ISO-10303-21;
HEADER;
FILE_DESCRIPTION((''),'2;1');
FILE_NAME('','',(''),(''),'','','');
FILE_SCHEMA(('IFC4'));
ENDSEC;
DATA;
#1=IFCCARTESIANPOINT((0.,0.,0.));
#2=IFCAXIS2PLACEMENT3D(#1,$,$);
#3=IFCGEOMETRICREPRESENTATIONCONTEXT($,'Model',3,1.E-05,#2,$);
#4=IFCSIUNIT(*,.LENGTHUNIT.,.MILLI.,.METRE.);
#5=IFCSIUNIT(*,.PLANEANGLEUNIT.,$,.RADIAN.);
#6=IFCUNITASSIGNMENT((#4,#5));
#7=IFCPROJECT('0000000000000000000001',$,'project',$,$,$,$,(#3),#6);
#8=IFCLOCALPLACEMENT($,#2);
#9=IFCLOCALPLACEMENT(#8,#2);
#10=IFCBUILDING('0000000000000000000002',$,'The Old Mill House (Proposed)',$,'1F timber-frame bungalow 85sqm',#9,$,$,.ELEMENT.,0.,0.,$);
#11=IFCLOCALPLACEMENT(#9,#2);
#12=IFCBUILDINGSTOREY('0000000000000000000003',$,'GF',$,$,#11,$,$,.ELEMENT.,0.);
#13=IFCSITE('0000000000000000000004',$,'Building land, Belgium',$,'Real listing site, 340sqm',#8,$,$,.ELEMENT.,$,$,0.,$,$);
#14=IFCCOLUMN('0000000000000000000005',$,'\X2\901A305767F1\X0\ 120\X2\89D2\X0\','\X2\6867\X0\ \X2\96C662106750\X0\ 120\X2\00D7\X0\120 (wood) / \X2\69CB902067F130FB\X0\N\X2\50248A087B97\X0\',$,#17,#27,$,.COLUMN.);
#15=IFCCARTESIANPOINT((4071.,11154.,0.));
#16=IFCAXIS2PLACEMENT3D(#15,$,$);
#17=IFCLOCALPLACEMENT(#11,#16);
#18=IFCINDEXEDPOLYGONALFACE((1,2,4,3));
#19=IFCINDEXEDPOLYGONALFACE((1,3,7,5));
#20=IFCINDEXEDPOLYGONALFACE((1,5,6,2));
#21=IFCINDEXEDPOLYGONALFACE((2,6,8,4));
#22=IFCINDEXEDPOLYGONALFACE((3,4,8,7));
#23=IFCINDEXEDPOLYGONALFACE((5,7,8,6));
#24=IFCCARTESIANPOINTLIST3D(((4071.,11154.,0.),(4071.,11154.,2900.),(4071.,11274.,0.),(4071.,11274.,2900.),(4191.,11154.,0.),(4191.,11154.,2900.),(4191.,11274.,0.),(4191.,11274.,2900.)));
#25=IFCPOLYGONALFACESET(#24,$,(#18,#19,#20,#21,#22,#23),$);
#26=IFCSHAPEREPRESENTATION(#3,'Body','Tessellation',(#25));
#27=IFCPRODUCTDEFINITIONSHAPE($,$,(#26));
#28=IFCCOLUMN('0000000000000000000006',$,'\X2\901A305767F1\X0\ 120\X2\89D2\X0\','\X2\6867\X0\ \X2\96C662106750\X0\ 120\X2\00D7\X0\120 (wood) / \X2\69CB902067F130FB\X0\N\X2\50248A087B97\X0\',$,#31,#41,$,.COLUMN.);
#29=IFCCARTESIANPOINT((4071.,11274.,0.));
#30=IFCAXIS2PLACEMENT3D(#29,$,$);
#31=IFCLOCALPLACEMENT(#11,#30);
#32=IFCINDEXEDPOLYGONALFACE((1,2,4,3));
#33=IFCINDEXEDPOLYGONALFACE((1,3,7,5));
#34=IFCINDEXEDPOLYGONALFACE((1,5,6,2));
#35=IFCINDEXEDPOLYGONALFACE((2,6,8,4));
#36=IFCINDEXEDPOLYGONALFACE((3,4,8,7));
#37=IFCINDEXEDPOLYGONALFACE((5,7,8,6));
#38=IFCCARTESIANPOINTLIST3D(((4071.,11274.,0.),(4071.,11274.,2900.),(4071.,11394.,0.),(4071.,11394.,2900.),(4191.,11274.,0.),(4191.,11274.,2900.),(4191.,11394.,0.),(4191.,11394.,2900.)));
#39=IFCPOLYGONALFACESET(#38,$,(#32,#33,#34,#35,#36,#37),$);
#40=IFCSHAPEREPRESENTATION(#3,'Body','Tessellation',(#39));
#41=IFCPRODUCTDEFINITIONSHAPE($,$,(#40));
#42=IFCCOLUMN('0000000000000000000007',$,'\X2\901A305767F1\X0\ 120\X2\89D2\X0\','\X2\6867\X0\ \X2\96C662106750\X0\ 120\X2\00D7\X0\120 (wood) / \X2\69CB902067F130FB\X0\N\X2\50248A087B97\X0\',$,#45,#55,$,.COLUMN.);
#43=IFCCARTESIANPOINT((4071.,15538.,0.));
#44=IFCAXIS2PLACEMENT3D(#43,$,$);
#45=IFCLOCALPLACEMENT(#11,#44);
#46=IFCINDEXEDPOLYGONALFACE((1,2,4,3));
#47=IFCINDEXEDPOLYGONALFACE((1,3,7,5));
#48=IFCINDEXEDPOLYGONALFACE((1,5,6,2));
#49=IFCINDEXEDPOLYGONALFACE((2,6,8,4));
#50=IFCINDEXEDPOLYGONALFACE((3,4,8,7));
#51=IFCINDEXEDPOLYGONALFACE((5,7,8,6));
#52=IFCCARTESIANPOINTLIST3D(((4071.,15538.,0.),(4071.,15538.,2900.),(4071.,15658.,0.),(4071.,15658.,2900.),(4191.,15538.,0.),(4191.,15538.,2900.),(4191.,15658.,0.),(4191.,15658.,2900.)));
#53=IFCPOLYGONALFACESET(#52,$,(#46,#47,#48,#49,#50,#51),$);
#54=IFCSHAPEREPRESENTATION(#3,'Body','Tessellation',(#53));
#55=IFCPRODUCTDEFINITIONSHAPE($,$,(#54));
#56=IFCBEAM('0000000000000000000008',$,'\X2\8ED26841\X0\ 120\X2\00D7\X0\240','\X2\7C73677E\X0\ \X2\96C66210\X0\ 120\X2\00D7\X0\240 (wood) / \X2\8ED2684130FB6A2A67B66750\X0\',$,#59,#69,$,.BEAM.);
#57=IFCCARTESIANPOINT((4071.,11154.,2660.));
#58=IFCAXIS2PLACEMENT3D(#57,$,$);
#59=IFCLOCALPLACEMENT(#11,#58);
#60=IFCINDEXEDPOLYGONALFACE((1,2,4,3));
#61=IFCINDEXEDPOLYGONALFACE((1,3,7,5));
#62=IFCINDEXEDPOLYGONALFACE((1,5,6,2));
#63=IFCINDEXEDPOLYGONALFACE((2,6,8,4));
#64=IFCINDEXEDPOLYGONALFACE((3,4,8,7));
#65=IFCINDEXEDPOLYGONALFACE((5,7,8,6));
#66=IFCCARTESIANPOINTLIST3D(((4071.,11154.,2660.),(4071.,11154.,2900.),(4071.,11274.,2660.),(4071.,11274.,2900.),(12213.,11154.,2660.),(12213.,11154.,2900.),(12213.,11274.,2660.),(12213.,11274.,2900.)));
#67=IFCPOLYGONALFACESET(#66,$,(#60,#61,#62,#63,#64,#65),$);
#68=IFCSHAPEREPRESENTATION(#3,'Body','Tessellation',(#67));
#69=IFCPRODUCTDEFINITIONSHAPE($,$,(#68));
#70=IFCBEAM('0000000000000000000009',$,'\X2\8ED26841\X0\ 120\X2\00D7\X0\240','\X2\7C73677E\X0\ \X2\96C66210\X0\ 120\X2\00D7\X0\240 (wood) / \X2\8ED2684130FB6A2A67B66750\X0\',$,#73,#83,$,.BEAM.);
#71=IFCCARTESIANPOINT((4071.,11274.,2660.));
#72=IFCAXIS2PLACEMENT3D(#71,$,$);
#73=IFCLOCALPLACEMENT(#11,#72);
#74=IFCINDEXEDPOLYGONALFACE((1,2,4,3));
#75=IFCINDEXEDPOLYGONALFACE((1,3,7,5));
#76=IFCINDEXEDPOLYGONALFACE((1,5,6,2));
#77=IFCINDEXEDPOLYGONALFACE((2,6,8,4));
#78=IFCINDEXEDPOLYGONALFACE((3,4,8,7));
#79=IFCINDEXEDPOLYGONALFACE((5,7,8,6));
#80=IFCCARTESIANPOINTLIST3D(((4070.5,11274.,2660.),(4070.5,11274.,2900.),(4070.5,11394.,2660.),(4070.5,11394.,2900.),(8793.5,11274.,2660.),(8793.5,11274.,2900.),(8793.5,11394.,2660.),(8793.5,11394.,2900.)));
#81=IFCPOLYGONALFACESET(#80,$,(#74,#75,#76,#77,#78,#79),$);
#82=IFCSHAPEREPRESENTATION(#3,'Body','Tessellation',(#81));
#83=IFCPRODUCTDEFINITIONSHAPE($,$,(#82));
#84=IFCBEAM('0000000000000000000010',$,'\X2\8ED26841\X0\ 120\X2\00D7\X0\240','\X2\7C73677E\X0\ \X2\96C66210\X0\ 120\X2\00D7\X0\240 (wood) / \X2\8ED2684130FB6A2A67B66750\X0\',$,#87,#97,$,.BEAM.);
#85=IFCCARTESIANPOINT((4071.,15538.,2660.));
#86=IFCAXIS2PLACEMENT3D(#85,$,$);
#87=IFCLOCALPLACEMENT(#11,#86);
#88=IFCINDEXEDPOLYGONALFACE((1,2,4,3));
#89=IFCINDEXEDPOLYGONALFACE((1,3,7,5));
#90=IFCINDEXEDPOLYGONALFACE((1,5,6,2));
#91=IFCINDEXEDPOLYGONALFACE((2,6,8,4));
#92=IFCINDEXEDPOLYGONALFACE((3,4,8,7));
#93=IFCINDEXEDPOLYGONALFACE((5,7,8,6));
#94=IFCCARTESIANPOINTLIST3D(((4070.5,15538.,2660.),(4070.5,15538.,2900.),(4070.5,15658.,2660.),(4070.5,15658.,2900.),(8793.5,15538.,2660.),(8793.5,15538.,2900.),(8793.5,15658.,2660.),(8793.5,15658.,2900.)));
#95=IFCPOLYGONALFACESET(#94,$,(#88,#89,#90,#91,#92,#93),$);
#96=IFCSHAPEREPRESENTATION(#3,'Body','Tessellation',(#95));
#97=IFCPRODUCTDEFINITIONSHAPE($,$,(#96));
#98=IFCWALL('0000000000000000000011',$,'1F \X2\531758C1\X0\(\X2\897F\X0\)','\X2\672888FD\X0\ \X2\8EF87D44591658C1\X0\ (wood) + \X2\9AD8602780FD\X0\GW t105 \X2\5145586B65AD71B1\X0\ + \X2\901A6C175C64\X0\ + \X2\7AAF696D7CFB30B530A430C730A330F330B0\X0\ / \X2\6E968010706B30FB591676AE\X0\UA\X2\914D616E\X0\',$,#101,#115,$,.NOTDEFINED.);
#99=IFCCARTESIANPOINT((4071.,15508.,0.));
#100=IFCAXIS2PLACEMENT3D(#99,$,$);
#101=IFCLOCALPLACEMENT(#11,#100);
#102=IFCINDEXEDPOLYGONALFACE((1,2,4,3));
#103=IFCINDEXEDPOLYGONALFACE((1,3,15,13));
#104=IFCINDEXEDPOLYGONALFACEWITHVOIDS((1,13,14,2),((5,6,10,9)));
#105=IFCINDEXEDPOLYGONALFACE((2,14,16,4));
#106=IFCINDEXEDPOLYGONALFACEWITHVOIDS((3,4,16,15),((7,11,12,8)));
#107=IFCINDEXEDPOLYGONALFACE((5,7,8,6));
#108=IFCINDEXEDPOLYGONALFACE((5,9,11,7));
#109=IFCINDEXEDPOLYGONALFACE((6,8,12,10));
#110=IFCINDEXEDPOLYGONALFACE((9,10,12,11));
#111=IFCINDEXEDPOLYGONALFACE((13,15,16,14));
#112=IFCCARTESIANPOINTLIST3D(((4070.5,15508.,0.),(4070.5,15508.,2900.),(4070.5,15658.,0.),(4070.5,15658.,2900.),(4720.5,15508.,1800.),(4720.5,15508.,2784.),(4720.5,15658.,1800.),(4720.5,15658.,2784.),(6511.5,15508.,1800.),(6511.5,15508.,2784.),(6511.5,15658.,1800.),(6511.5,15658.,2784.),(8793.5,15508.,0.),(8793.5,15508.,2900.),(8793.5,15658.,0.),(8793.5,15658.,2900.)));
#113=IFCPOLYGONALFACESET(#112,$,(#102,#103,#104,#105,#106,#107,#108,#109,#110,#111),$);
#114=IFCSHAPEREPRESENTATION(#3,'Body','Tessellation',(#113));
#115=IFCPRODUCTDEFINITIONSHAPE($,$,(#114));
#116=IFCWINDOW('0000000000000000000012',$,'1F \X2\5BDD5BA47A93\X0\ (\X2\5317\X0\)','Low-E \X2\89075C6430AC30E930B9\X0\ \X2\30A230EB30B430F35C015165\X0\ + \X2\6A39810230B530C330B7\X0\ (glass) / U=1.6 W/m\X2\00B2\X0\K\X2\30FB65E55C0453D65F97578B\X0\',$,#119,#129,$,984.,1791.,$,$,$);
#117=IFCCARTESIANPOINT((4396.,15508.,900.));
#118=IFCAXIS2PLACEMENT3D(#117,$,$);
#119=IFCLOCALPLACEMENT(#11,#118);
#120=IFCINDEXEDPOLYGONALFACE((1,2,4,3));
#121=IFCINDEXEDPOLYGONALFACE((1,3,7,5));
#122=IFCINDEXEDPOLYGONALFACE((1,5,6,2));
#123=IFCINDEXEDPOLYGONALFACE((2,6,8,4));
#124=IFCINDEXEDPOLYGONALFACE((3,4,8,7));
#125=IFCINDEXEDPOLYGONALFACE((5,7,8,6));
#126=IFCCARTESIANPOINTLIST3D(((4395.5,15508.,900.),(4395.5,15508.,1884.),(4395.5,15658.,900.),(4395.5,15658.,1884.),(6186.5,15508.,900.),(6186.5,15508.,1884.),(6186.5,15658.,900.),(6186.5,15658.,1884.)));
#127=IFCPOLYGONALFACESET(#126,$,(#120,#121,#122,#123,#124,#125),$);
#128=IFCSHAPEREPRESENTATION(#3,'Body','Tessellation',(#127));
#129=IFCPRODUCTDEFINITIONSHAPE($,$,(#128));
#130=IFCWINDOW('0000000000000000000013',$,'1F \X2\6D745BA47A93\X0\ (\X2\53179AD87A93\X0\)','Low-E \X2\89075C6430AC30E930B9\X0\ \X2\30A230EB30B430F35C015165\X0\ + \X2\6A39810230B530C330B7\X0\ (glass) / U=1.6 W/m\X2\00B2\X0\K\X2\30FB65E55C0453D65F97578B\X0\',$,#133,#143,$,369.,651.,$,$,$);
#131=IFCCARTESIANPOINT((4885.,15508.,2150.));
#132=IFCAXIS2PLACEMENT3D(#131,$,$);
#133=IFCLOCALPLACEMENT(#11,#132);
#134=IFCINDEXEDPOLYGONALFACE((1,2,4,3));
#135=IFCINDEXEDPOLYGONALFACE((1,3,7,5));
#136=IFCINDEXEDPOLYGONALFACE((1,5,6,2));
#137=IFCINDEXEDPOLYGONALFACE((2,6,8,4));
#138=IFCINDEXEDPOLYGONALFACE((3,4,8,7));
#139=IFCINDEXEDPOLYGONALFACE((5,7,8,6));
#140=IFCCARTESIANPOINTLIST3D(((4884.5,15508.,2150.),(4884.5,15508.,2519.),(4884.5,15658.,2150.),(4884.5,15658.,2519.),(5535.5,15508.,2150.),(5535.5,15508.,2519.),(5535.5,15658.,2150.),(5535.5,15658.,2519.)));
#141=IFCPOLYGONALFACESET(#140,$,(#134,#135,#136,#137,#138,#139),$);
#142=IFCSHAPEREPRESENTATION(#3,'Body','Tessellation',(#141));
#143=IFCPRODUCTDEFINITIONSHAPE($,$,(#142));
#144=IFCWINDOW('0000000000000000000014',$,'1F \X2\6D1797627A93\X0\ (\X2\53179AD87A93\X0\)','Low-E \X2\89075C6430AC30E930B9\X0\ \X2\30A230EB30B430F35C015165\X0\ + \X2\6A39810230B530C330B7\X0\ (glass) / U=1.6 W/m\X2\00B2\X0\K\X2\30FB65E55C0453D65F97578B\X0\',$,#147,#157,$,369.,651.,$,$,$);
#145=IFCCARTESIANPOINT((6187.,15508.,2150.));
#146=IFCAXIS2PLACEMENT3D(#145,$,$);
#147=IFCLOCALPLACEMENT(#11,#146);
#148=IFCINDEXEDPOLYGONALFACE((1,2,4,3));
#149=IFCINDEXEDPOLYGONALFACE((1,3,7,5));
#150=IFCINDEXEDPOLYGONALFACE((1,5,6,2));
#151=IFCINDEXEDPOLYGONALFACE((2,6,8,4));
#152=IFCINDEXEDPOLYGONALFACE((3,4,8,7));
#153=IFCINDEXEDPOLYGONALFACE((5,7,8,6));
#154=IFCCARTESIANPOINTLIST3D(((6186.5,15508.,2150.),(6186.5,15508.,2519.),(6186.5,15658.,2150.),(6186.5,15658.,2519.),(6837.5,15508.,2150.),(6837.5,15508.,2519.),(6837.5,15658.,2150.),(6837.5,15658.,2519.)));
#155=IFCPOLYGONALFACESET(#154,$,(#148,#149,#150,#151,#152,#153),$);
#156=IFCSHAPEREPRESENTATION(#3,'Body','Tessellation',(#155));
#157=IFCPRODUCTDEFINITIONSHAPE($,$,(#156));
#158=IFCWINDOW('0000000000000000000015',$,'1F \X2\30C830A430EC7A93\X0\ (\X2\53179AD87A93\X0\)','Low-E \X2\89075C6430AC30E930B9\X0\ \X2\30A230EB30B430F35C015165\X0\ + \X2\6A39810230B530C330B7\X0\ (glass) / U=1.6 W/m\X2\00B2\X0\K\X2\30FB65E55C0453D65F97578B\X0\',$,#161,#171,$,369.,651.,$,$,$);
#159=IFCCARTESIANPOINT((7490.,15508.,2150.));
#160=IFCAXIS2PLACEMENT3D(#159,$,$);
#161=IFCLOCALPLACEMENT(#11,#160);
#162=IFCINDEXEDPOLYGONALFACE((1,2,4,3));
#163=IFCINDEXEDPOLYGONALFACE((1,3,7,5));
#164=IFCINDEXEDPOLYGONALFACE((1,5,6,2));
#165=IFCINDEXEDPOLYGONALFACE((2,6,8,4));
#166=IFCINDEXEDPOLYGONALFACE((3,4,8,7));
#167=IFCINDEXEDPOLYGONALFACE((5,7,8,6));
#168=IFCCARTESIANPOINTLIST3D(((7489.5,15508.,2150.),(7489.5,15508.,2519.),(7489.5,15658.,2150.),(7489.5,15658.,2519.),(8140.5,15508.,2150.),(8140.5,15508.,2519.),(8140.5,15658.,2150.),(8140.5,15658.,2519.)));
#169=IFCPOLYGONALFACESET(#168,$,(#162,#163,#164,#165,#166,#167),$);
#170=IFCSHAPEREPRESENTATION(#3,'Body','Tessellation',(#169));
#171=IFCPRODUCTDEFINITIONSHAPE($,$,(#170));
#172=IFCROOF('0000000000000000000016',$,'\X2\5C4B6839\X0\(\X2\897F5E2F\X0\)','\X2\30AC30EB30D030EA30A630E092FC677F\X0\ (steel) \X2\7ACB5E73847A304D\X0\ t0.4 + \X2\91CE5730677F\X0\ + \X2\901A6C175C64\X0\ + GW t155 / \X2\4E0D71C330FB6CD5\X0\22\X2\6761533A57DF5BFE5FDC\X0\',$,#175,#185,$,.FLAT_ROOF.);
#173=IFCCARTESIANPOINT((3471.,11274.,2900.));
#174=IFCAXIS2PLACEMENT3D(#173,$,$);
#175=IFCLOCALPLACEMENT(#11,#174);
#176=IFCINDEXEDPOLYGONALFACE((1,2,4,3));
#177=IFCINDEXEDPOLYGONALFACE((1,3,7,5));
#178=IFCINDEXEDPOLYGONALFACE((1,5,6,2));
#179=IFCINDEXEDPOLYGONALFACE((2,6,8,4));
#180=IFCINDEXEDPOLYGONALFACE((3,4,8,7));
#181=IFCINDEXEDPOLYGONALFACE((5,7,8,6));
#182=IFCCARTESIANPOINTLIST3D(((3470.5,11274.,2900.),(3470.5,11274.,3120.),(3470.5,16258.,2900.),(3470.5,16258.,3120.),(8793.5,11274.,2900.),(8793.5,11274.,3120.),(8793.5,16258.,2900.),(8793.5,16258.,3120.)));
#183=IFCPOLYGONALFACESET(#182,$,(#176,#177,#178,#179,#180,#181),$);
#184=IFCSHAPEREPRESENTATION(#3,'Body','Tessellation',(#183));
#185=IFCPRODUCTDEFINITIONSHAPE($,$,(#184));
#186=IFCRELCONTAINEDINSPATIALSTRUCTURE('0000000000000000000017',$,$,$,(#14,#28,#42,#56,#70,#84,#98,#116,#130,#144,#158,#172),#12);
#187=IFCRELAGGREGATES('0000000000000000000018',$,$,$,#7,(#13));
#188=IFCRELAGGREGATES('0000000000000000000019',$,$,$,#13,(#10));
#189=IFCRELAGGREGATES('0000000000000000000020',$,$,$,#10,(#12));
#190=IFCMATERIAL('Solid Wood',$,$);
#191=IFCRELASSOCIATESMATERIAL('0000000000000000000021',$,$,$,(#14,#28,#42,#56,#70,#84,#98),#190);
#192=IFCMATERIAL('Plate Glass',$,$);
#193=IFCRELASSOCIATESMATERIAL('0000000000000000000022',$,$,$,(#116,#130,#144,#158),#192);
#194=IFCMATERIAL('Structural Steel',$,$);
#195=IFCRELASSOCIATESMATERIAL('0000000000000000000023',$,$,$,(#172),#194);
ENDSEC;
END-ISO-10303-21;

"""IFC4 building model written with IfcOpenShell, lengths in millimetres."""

from ifc_helpers import new_model, si_unit, frame, frame_2d, origin, place, context, project, spatial, rectangle, extrude, material, element, fill, save


model = new_model("IFC4")

# Units and contexts
model_context = context("Model", 3, precision=1e-05, world=origin())
ifc_project = project(units=[si_unit("LENGTHUNIT", "METRE", prefix="MILLI"), si_unit("PLANEANGLEUNIT", "RADIAN")], contexts=[model_context])

# Site, building, storey
site_placement = place(None, origin())
site = spatial("IfcSite", under=ifc_project, at=site_placement, Name="Building land, Belgium", ObjectType="Real listing site, 340sqm", CompositionType="ELEMENT", RefElevation=0.0)
building_placement = place(site_placement, origin())
building = spatial("IfcBuilding", under=site, at=building_placement, Name="The Old Mill House (Proposed)", ObjectType="1F timber-frame bungalow 85sqm", CompositionType="ELEMENT", ElevationOfRefHeight=0.0, ElevationOfTerrain=0.0)
storey_placement = place(building_placement, origin())
storey = spatial("IfcBuildingStorey", under=building, at=storey_placement, Name="GF", CompositionType="ELEMENT", Elevation=0.0)

# Columns
ifc_material_1 = material(Name="Solid Wood")
column_1_placement = place(storey_placement, frame((4071.0, 11154.0, 0.0)))
element("IfcColumn", 1, at=column_1_placement, inside=storey, material=ifc_material_1, Name="通し柱 120角", Description="桧 集成材 120×120 (wood) / 構造柱・N値計算", PredefinedType="COLUMN", context=model_context, shape_type="SweptSolid", body=[
    extrude(rectangle(XDim=120.0, YDim=120.0, at=frame_2d((60.0, 60.0))), frame((4071.0, 11154.0, 0.0)), (0.0, 0.0, 1.0), 2900.0),
])
column_2_placement = place(storey_placement, frame((4071.0, 11274.0, 0.0)))
element("IfcColumn", 2, at=column_2_placement, inside=storey, material=ifc_material_1, Name="通し柱 120角", Description="桧 集成材 120×120 (wood) / 構造柱・N値計算", PredefinedType="COLUMN", context=model_context, shape_type="SweptSolid", body=[
    extrude(rectangle(XDim=120.0, YDim=120.0, at=frame_2d((60.0, 60.0))), frame((4071.0, 11274.0, 0.0)), (0.0, 0.0, 1.0), 2900.0),
])
column_3_placement = place(storey_placement, frame((4071.0, 15538.0, 0.0)))
element("IfcColumn", 3, at=column_3_placement, inside=storey, material=ifc_material_1, Name="通し柱 120角", Description="桧 集成材 120×120 (wood) / 構造柱・N値計算", PredefinedType="COLUMN", context=model_context, shape_type="SweptSolid", body=[
    extrude(rectangle(XDim=120.0, YDim=120.0, at=frame_2d((60.0, 60.0))), frame((4071.0, 15538.0, 0.0)), (0.0, 0.0, 1.0), 2900.0),
])

# Beams
beam_1_placement = place(storey_placement, frame((4071.0, 11154.0, 2660.0)))
element("IfcBeam", 4, at=beam_1_placement, inside=storey, material=ifc_material_1, Name="軒桁 120×240", Description="米松 集成 120×240 (wood) / 軒桁・横架材", PredefinedType="BEAM", context=model_context, shape_type="SweptSolid", body=[
    extrude(rectangle(XDim=8142.0, YDim=120.0, at=frame_2d((4071.0, 60.0))), frame((4071.0, 11154.0, 2660.0)), (0.0, 0.0, 1.0), 240.0),
])
beam_2_placement = place(storey_placement, frame((4071.0, 11274.0, 2660.0)))
element("IfcBeam", 5, at=beam_2_placement, inside=storey, material=ifc_material_1, Name="軒桁 120×240", Description="米松 集成 120×240 (wood) / 軒桁・横架材", PredefinedType="BEAM", context=model_context, shape_type="SweptSolid", body=[
    extrude(rectangle(XDim=4723.0, YDim=120.0, at=frame_2d((2361.0, 60.0))), frame((4071.0, 11274.0, 2660.0)), (0.0, 0.0, 1.0), 240.0),
])
beam_3_placement = place(storey_placement, frame((4071.0, 15538.0, 2660.0)))
element("IfcBeam", 6, at=beam_3_placement, inside=storey, material=ifc_material_1, Name="軒桁 120×240", Description="米松 集成 120×240 (wood) / 軒桁・横架材", PredefinedType="BEAM", context=model_context, shape_type="SweptSolid", body=[
    extrude(rectangle(XDim=4723.0, YDim=120.0, at=frame_2d((2361.0, 60.0))), frame((4071.0, 15538.0, 2660.0)), (0.0, 0.0, 1.0), 240.0),
])

# Wall, openings, windows
wall_1_placement = place(storey_placement, frame((4071.0, 15508.0, 0.0)))
wall_1 = element("IfcWall", 7, at=wall_1_placement, inside=storey, material=ifc_material_1, Name="1F 北壁(西)", Description="木製 軸組外壁 (wood) + 高性能GW t105 充填断熱 + 通気層 + 窯業系サイディング / 準耐火・外皮UA配慮", PredefinedType="NOTDEFINED", context=model_context, shape_type="SweptSolid", body=[
    extrude(rectangle(XDim=4723.0, YDim=150.0, at=frame_2d((2361.0, 75.0))), frame((4071.0, 15508.0, 0.0)), (0.0, 0.0, 1.0), 2900.0),
])
opening_1_placement = place(storey_placement, frame((4396.0, 15508.0, 900.0)))
opening_1 = element("IfcOpeningElement", 8, at=opening_1_placement, cuts=wall_1, PredefinedType="NOTDEFINED", context=model_context, shape_type="SweptSolid", body=[
    extrude(rectangle(XDim=1791.0, YDim=150.0, at=frame_2d((895.0, 75.0))), frame((4396.0, 15508.0, 900.0)), (0.0, 0.0, 1.0), 984.0),
])
opening_2_placement = place(storey_placement, frame((4885.0, 15508.0, 2150.0)))
opening_2 = element("IfcOpeningElement", 9, at=opening_2_placement, cuts=wall_1, PredefinedType="NOTDEFINED", context=model_context, shape_type="SweptSolid", body=[
    extrude(rectangle(XDim=651.0, YDim=150.0, at=frame_2d((325.0, 75.0))), frame((4885.0, 15508.0, 2150.0)), (0.0, 0.0, 1.0), 369.0),
])
opening_3_placement = place(storey_placement, frame((6187.0, 15508.0, 2150.0)))
opening_3 = element("IfcOpeningElement", 10, at=opening_3_placement, cuts=wall_1, PredefinedType="NOTDEFINED", context=model_context, shape_type="SweptSolid", body=[
    extrude(rectangle(XDim=651.0, YDim=150.0, at=frame_2d((325.0, 75.0))), frame((6187.0, 15508.0, 2150.0)), (0.0, 0.0, 1.0), 369.0),
])
opening_4_placement = place(storey_placement, frame((7490.0, 15508.0, 2150.0)))
opening_4 = element("IfcOpeningElement", 11, at=opening_4_placement, cuts=wall_1, PredefinedType="NOTDEFINED", context=model_context, shape_type="SweptSolid", body=[
    extrude(rectangle(XDim=651.0, YDim=150.0, at=frame_2d((325.0, 75.0))), frame((7490.0, 15508.0, 2150.0)), (0.0, 0.0, 1.0), 369.0),
])
ifc_material_2 = material(Name="Plate Glass")
window_1_placement = place(storey_placement, frame((4396.0, 15508.0, 900.0)))
window_1 = element("IfcWindow", 12, at=window_1_placement, inside=storey, material=ifc_material_2, Name="1F 寝室窓 (北)", Description="Low-E 複層ガラス アルゴン封入 + 樹脂サッシ (glass) / U=1.6 W/m²K・日射取得型", OverallHeight=984.0, OverallWidth=1791.0, context=model_context, shape_type="SweptSolid", body=[
    extrude(rectangle(XDim=1791.0, YDim=150.0, at=frame_2d((895.0, 75.0))), frame((4396.0, 15508.0, 900.0)), (0.0, 0.0, 1.0), 984.0),
])
fill(opening_1, window_1)
window_2_placement = place(storey_placement, frame((4885.0, 15508.0, 2150.0)))
window_2 = element("IfcWindow", 13, at=window_2_placement, inside=storey, material=ifc_material_2, Name="1F 浴室窓 (北高窓)", Description="Low-E 複層ガラス アルゴン封入 + 樹脂サッシ (glass) / U=1.6 W/m²K・日射取得型", OverallHeight=369.0, OverallWidth=651.0, context=model_context, shape_type="SweptSolid", body=[
    extrude(rectangle(XDim=651.0, YDim=150.0, at=frame_2d((325.0, 75.0))), frame((4885.0, 15508.0, 2150.0)), (0.0, 0.0, 1.0), 369.0),
])
fill(opening_2, window_2)
window_3_placement = place(storey_placement, frame((6187.0, 15508.0, 2150.0)))
window_3 = element("IfcWindow", 14, at=window_3_placement, inside=storey, material=ifc_material_2, Name="1F 洗面窓 (北高窓)", Description="Low-E 複層ガラス アルゴン封入 + 樹脂サッシ (glass) / U=1.6 W/m²K・日射取得型", OverallHeight=369.0, OverallWidth=651.0, context=model_context, shape_type="SweptSolid", body=[
    extrude(rectangle(XDim=651.0, YDim=150.0, at=frame_2d((325.0, 75.0))), frame((6187.0, 15508.0, 2150.0)), (0.0, 0.0, 1.0), 369.0),
])
fill(opening_3, window_3)
window_4_placement = place(storey_placement, frame((7490.0, 15508.0, 2150.0)))
window_4 = element("IfcWindow", 15, at=window_4_placement, inside=storey, material=ifc_material_2, Name="1F トイレ窓 (北高窓)", Description="Low-E 複層ガラス アルゴン封入 + 樹脂サッシ (glass) / U=1.6 W/m²K・日射取得型", OverallHeight=369.0, OverallWidth=651.0, context=model_context, shape_type="SweptSolid", body=[
    extrude(rectangle(XDim=651.0, YDim=150.0, at=frame_2d((325.0, 75.0))), frame((7490.0, 15508.0, 2150.0)), (0.0, 0.0, 1.0), 369.0),
])
fill(opening_4, window_4)

# Roof
ifc_material_3 = material(Name="Structural Steel")
roof_placement = place(storey_placement, frame((3471.0, 11274.0, 2900.0)))
element("IfcRoof", 16, at=roof_placement, inside=storey, material=ifc_material_3, Name="屋根(西帯)", Description="ガルバリウム鋼板 (steel) 立平葺き t0.4 + 野地板 + 通気層 + GW t155 / 不燃・法22条区域対応", PredefinedType="FLAT_ROOF", context=model_context, shape_type="SweptSolid", body=[
    extrude(rectangle(XDim=5323.0, YDim=4984.0, at=frame_2d((2661.0, 2492.0))), frame((3471.0, 11274.0, 2900.0)), (0.0, 0.0, 1.0), 220.0),
])

save(model, "model.ifc")
